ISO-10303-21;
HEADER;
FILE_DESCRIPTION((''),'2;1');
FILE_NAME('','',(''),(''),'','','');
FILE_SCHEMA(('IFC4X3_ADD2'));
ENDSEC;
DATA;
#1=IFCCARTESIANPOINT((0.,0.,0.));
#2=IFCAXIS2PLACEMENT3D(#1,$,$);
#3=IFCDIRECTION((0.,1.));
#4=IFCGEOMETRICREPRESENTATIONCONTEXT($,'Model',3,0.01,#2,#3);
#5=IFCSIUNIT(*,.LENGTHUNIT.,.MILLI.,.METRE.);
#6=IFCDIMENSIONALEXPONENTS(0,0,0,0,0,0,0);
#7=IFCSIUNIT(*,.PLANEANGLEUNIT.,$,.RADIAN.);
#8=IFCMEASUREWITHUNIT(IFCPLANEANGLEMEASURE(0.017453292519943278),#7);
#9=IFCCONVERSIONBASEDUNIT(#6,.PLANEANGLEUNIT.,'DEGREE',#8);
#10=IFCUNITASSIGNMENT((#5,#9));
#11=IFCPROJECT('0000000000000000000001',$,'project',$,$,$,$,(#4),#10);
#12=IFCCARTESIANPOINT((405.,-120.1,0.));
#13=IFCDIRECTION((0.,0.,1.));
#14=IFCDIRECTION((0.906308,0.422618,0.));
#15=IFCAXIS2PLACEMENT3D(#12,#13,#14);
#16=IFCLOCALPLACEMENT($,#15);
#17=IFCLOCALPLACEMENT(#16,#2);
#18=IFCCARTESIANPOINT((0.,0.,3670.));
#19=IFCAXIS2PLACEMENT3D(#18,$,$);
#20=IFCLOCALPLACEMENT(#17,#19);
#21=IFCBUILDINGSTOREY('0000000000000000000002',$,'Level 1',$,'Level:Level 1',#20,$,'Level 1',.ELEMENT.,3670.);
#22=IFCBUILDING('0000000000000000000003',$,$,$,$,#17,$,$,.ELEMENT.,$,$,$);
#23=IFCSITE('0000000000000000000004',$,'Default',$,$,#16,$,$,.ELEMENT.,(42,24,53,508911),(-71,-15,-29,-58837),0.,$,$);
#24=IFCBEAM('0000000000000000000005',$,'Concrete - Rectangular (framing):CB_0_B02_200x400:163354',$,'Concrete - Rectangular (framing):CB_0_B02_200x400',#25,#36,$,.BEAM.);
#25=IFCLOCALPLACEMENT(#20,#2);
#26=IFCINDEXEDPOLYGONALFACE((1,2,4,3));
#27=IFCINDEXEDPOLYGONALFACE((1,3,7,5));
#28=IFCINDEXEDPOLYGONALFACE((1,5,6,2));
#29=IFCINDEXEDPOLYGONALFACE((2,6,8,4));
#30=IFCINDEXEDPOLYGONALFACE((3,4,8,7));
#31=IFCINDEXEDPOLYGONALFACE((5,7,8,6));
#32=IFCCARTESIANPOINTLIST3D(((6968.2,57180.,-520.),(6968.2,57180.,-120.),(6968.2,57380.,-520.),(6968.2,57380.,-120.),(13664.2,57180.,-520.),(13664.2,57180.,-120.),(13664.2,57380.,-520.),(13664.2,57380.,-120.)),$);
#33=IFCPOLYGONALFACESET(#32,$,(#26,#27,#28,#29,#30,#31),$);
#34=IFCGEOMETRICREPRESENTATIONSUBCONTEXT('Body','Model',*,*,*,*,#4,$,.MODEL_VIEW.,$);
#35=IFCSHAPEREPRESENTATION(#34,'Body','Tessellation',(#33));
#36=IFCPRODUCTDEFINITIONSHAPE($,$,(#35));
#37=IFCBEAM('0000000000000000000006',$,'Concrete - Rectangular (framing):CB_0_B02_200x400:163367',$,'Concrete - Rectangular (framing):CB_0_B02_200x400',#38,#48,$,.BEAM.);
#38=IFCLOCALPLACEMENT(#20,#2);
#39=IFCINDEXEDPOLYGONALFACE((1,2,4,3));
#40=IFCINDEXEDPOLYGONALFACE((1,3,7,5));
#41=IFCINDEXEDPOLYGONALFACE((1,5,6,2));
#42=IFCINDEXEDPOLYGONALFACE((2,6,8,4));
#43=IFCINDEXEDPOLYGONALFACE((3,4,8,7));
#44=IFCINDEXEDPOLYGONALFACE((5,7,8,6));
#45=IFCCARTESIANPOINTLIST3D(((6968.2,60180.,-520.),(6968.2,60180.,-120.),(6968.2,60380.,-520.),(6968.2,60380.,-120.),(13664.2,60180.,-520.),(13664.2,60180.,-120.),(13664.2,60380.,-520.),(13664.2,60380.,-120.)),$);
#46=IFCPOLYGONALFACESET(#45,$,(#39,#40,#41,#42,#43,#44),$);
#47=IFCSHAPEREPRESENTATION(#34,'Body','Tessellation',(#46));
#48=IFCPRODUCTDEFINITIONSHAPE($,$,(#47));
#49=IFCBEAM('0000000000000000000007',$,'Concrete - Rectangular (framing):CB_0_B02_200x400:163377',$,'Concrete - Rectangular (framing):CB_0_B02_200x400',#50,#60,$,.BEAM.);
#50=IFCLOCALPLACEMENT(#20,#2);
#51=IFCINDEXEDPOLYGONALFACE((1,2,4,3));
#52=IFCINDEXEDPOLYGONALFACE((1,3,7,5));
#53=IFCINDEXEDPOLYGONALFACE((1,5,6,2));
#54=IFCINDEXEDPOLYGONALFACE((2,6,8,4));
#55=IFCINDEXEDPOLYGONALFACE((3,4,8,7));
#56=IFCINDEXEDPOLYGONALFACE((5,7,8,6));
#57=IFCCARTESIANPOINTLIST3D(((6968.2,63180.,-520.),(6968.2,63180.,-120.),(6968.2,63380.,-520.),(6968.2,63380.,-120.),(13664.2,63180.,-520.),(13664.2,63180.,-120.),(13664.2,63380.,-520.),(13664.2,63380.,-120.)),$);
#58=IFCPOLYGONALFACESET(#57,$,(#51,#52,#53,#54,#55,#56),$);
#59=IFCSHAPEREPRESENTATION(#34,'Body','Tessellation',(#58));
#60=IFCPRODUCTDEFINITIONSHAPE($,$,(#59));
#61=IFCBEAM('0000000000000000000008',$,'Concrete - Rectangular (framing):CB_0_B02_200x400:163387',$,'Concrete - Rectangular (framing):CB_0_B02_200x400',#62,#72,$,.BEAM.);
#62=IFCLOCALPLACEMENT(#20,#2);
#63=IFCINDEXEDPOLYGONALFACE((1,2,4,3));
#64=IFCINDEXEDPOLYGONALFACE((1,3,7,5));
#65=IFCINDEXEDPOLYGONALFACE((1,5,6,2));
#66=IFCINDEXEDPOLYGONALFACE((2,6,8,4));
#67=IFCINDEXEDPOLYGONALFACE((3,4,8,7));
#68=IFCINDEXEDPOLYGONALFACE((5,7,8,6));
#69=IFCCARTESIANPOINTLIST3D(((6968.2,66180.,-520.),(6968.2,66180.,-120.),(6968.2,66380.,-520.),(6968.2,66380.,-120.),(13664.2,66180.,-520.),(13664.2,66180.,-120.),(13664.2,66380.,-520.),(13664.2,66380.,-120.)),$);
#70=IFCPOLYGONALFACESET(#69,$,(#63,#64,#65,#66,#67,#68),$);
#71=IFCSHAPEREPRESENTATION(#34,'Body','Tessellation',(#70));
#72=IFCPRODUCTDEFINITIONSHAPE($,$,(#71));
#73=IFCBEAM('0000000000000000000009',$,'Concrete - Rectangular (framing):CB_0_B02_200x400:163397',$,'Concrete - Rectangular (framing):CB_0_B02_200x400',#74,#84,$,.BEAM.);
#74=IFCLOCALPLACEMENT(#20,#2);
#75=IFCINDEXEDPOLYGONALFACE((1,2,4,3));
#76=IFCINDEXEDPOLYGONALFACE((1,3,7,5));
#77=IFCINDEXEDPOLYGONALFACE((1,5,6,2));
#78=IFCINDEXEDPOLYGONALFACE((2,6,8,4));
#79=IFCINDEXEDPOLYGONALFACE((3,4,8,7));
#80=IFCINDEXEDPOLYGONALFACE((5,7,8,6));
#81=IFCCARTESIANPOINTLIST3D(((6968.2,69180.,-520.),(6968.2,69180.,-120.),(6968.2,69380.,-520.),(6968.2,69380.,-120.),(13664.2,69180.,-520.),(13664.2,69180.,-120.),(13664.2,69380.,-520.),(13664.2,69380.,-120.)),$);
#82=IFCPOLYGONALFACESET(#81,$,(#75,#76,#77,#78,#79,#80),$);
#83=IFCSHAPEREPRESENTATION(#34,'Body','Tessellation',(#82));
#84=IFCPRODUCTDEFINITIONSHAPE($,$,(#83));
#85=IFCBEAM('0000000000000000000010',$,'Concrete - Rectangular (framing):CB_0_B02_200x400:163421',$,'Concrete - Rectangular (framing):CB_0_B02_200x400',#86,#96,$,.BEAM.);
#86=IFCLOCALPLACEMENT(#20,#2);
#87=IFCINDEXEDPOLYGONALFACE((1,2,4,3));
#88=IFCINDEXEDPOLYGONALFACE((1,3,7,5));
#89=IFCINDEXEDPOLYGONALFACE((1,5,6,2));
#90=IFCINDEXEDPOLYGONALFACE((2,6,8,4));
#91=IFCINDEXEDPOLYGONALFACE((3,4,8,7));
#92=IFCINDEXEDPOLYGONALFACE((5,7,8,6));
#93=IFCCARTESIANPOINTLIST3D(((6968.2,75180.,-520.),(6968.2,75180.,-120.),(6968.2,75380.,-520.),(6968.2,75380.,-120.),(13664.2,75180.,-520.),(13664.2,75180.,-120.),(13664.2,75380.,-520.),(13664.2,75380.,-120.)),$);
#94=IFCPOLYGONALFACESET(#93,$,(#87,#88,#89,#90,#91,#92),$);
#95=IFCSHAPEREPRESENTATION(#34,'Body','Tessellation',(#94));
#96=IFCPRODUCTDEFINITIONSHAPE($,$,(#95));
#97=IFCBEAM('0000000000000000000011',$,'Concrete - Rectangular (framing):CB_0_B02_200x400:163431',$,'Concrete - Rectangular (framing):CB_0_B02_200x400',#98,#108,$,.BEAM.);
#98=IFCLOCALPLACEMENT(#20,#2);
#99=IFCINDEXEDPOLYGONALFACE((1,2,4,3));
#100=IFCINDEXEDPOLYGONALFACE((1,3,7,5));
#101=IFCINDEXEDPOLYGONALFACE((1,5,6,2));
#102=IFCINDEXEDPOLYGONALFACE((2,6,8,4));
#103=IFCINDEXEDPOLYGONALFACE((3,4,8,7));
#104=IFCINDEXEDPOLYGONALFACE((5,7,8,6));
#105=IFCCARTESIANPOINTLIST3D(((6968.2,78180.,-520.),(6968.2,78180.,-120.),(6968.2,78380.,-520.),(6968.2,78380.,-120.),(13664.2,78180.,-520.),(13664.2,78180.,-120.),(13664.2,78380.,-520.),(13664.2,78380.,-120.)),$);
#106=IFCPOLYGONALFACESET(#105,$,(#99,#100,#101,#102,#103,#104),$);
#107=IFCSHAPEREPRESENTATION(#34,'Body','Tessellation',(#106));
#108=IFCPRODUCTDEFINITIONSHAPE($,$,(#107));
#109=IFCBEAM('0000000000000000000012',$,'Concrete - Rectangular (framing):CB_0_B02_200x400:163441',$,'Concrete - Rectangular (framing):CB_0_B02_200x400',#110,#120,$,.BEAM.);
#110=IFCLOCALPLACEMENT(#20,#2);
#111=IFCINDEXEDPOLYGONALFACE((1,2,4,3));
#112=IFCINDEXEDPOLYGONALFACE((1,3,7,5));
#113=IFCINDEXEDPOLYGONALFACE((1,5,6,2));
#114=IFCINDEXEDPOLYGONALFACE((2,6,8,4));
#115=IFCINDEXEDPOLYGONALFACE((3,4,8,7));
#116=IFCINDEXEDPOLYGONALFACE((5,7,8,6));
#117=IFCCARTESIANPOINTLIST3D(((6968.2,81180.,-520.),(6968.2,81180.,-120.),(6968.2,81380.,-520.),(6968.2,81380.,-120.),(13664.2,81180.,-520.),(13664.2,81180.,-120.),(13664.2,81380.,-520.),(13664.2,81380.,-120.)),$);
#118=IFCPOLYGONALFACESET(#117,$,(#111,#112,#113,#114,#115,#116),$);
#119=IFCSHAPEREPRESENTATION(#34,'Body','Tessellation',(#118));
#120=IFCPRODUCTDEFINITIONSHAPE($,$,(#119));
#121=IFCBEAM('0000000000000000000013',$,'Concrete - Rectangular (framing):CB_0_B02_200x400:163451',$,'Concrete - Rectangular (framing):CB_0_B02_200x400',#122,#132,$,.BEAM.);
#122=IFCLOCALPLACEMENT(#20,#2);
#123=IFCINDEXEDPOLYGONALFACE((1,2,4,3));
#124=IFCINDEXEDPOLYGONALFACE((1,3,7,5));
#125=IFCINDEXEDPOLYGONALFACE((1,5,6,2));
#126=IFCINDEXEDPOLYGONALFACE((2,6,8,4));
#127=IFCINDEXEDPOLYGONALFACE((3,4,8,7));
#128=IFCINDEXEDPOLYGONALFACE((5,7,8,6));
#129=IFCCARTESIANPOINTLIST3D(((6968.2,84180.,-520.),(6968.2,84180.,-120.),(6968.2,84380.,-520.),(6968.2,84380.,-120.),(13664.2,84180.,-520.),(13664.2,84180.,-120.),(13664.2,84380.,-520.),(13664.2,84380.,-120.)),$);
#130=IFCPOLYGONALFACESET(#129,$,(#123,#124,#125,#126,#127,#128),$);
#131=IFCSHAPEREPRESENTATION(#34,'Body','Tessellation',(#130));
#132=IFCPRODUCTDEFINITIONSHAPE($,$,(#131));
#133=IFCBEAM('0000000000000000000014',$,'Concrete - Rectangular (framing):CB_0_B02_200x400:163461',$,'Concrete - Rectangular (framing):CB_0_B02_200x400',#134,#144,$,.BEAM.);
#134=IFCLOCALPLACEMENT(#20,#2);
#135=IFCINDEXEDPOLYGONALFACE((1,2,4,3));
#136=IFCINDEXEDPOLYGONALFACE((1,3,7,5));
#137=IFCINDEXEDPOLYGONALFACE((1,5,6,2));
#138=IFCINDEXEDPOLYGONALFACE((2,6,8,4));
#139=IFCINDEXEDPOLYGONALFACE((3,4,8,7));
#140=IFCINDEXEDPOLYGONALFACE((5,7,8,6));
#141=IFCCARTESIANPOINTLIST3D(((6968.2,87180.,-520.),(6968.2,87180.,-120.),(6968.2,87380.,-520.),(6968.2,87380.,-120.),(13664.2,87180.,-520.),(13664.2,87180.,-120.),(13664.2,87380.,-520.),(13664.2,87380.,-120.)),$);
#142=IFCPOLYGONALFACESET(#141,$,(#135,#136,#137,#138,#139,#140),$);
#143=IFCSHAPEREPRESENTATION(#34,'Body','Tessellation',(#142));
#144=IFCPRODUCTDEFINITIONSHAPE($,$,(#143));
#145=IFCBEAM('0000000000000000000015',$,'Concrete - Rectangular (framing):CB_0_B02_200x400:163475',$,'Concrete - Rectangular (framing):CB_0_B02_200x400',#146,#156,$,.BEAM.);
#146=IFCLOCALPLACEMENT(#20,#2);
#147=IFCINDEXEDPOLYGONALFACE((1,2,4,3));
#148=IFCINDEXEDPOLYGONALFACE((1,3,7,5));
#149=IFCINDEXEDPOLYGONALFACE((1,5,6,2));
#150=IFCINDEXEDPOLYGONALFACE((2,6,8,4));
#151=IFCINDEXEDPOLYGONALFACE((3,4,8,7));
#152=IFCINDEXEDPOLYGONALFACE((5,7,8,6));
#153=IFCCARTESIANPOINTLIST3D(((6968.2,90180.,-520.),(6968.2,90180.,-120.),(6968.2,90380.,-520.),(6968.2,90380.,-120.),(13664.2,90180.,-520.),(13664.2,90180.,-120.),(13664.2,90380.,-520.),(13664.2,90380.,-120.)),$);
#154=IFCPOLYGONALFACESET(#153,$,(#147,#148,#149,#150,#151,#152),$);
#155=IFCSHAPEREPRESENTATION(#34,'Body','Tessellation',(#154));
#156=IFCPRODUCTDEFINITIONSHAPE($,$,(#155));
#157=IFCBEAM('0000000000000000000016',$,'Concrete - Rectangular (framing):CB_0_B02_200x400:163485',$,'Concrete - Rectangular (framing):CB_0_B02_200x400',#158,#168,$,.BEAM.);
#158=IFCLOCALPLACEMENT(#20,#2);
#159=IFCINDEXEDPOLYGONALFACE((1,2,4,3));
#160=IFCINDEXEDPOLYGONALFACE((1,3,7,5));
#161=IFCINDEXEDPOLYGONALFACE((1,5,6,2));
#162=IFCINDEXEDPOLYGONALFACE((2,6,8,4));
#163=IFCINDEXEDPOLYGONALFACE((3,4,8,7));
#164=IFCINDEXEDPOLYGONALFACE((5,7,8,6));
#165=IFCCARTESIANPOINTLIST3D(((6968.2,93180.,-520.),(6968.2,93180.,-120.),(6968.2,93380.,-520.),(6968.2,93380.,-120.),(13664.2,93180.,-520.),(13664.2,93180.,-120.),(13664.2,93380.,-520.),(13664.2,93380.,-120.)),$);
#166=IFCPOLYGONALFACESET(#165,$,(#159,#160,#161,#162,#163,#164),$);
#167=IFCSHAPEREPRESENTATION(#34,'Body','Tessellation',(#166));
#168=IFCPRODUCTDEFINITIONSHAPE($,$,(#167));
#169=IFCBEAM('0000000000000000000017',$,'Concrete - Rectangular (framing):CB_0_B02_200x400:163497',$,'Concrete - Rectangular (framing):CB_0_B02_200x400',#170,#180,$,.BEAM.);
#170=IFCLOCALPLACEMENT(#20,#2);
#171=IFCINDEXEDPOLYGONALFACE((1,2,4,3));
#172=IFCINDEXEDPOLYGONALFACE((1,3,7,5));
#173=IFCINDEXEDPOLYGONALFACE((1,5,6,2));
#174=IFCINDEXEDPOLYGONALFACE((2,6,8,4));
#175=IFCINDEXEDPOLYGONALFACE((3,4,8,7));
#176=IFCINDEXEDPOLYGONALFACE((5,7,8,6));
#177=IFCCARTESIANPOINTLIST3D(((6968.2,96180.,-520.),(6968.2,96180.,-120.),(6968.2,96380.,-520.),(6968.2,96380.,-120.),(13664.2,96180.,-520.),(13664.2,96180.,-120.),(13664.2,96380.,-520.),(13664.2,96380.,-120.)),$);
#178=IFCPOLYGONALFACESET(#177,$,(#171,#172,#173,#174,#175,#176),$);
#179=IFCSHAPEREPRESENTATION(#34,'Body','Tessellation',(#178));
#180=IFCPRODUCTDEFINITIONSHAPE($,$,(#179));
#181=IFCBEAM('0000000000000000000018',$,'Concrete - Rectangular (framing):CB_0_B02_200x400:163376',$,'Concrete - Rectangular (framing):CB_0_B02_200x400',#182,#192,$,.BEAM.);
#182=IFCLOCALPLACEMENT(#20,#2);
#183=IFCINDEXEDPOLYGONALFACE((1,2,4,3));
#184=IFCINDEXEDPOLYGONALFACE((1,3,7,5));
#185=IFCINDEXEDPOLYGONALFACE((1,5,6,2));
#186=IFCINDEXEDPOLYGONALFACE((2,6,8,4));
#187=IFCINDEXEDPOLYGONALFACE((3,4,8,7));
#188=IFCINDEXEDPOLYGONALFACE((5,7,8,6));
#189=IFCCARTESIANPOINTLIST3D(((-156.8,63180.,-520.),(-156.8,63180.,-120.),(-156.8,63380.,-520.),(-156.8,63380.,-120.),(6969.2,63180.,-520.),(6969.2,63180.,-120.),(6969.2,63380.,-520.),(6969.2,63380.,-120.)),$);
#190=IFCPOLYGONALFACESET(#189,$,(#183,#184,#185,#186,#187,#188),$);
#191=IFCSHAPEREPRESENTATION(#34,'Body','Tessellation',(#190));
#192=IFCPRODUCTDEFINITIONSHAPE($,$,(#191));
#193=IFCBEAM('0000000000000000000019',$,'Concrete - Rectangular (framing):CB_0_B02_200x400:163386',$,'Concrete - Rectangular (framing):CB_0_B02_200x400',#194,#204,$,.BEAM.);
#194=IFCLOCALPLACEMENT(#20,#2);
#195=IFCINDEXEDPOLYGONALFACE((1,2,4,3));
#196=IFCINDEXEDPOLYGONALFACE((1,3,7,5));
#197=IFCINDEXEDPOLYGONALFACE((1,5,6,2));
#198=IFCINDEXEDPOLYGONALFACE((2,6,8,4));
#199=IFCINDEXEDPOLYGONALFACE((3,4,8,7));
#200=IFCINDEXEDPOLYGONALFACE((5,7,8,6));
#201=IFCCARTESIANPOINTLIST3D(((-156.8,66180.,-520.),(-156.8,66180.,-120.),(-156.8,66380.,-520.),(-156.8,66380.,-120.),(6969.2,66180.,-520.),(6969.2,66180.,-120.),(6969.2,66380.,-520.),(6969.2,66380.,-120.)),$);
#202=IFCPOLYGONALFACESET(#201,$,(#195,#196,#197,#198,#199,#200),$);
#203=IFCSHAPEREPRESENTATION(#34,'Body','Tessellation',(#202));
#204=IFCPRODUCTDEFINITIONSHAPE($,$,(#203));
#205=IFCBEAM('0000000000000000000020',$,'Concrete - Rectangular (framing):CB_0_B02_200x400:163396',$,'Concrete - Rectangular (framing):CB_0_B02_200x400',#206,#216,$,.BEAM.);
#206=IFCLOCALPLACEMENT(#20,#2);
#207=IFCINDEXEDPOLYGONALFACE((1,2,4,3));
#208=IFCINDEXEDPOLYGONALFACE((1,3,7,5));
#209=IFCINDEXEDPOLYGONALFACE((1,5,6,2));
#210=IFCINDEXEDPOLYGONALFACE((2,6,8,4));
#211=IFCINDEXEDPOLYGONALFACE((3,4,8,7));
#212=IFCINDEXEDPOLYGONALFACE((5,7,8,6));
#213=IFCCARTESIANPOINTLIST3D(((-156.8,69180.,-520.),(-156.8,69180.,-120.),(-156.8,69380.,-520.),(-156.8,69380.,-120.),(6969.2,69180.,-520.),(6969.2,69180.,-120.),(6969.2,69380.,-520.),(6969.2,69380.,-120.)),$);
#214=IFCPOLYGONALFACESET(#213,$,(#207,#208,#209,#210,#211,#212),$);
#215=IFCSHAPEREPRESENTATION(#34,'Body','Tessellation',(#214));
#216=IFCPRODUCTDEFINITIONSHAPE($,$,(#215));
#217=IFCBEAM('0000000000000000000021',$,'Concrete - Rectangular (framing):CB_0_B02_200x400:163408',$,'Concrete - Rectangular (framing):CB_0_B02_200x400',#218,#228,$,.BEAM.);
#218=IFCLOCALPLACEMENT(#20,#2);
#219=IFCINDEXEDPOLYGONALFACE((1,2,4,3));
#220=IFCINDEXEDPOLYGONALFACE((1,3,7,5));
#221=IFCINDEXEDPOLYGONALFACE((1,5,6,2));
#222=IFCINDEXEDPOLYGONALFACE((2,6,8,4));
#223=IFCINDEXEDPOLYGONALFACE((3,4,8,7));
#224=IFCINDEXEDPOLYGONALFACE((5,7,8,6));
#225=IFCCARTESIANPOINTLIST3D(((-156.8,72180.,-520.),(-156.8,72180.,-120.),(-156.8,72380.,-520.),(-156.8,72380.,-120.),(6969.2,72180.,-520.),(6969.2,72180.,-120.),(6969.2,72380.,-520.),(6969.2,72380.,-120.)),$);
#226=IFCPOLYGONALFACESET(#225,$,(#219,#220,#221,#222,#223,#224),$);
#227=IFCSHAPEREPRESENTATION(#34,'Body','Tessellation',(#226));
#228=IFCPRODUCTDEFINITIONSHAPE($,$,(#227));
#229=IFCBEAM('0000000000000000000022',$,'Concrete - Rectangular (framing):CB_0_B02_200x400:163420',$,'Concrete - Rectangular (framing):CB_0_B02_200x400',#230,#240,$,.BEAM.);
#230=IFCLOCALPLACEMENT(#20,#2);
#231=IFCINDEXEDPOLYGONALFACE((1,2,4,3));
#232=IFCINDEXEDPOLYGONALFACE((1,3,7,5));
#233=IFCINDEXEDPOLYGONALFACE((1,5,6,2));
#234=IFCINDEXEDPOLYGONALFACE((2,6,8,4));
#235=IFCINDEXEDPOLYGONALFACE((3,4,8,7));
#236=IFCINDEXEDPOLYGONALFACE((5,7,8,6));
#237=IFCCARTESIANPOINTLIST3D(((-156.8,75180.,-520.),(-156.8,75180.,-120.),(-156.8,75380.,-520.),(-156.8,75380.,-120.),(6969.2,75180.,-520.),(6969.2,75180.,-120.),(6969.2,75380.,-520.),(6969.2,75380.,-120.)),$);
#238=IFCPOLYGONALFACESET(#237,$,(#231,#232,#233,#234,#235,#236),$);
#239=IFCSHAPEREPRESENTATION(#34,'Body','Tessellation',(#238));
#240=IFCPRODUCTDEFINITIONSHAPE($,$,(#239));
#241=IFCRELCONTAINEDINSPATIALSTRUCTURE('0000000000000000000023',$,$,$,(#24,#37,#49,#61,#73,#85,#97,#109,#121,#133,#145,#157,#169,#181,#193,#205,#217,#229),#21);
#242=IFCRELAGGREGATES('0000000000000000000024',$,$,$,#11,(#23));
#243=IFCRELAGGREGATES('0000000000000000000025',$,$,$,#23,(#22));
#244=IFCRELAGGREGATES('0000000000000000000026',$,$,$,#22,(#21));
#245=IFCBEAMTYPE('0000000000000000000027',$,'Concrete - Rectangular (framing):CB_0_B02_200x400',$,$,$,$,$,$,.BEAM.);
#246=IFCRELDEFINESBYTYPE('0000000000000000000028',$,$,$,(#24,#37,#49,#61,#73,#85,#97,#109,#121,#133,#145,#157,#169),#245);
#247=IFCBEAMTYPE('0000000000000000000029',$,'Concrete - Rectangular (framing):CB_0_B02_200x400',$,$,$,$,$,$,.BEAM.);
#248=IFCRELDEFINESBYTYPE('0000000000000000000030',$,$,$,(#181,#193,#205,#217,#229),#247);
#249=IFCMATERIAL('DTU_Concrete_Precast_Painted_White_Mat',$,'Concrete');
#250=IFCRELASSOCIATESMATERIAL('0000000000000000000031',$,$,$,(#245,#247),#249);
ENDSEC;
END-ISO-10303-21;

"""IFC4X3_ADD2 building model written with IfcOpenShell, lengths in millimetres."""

from ifc_helpers import new_model, entity, si_unit, converted_unit, direction, frame, frame_2d, origin, origin_2d_with_axis, place, context, subcontext, project, spatial, rectangle, extrude, source, transform, mapped, material, material_profile, profile_set, type_object, type_shapes, element, save


model = new_model("IFC4X3_ADD2")

# Units and contexts
model_context = context("Model", 3, precision=0.01, world=origin(), true_north=direction((0.0, 1.0)))
body_context = subcontext(model_context, "Body", "Model", "MODEL_VIEW")
ifc_project = project(units=[si_unit("LENGTHUNIT", "METRE", prefix="MILLI"), converted_unit("PLANEANGLEUNIT", "DEGREE", entity("IfcPlaneAngleMeasure", 0.017453292519943278), si_unit("PLANEANGLEUNIT", "RADIAN"), dimensions=[0, 0, 0, 0, 0, 0, 0])], contexts=[model_context])

# Site, building, storey
site_placement = place(None, frame((405.0, -120.1, 0.0), z_axis=(0.0, 0.0, 1.0), x_axis=(0.906308, 0.422618, 0.0)))
site = spatial("IfcSite", under=ifc_project, at=site_placement, Name="Default", CompositionType="ELEMENT", RefLatitude=(42, 24, 53, 508911), RefLongitude=(-71, -15, -29, -58837), RefElevation=0.0)
building_placement = place(site_placement, origin())
building = spatial("IfcBuilding", under=site, at=building_placement, CompositionType="ELEMENT")
storey_placement = place(building_placement, frame((0.0, 0.0, 3670.0)))
storey = spatial("IfcBuildingStorey", under=building, at=storey_placement, Name="Level 1", ObjectType="Level:Level 1", LongName="Level 1", CompositionType="ELEMENT", Elevation=3670.0)

# Beams
ifc_material = material(Name="DTU_Concrete_Precast_Painted_White_Mat", Category="Concrete")
ifc_material_profile_1 = material_profile(ifc_material, rectangle(XDim=7035.5, YDim=200.0, at=frame_2d((0.0, 0.0), x_axis=(1.0, 0.0))), Name="CB_0_B02_200x400")
ifc_profile_set_1 = profile_set([ifc_material_profile_1], Name="CB_0_B02_200x400")
beam_type_1 = type_object("IfcBeamType", Name="Concrete - Rectangular (framing):CB_0_B02_200x400", PredefinedType="BEAM", material=ifc_profile_set_1)
shared_shape_1 = source(origin(), body_context, "Body", "SweptSolid", [
    extrude(rectangle(XDim=6696.0, YDim=200.0, at=origin_2d_with_axis()), frame((0.0, 0.0, -200.0), z_axis=(0.0, 0.0, 1.0), x_axis=(-1.0, 0.0, 0.0)), (0.0, 0.0, 1.0), 400.0),
])
type_shapes(beam_type_1, [shared_shape_1])
for number, where, name in (
    (1, (10316.2, 57280.0, -320.0), "Concrete - Rectangular (framing):CB_0_B02_200x400:163354"),
    (2, (10316.2, 60280.0, -320.0), "Concrete - Rectangular (framing):CB_0_B02_200x400:163367"),
    (3, (10316.2, 63280.0, -320.0), "Concrete - Rectangular (framing):CB_0_B02_200x400:163377"),
    (4, (10316.2, 66280.0, -320.0), "Concrete - Rectangular (framing):CB_0_B02_200x400:163387"),
    (5, (10316.2, 69280.0, -320.0), "Concrete - Rectangular (framing):CB_0_B02_200x400:163397"),
    (6, (10316.2, 75280.0, -320.0), "Concrete - Rectangular (framing):CB_0_B02_200x400:163421"),
    (7, (10316.2, 78280.0, -320.0), "Concrete - Rectangular (framing):CB_0_B02_200x400:163431"),
    (8, (10316.2, 81280.0, -320.0), "Concrete - Rectangular (framing):CB_0_B02_200x400:163441"),
    (9, (10316.2, 84280.0, -320.0), "Concrete - Rectangular (framing):CB_0_B02_200x400:163451"),
    (10, (10316.2, 87280.0, -320.0), "Concrete - Rectangular (framing):CB_0_B02_200x400:163461"),
    (11, (10316.2, 90280.0, -320.0), "Concrete - Rectangular (framing):CB_0_B02_200x400:163475"),
    (12, (10316.2, 93280.0, -320.0), "Concrete - Rectangular (framing):CB_0_B02_200x400:163485"),
    (13, (10316.2, 96280.0, -320.0), "Concrete - Rectangular (framing):CB_0_B02_200x400:163497"),
):
    element("IfcBeam", number, at=place(storey_placement, frame(where)), inside=storey, type_object=beam_type_1, Name=name, ObjectType="Concrete - Rectangular (framing):CB_0_B02_200x400", PredefinedType="BEAM", context=body_context, shape_type="MappedRepresentation", body=[
        mapped(shared_shape_1, transform((0.0, 0.0, 0.0), scale=1.0)),
    ])
beam_type_2 = type_object("IfcBeamType", Name="Concrete - Rectangular (framing):CB_0_B02_200x400", PredefinedType="BEAM", material=ifc_profile_set_1)
shared_shape_2 = source(origin(), body_context, "Body", "SweptSolid", [
    extrude(rectangle(XDim=7126.0, YDim=200.0, at=origin_2d_with_axis()), frame((0.0, 0.0, -200.0), z_axis=(0.0, 0.0, 1.0), x_axis=(-1.0, 0.0, 0.0)), (0.0, 0.0, 1.0), 400.0),
])
type_shapes(beam_type_2, [shared_shape_2])
for number, where, z_axis, x_axis, name in (
    (14, (3406.2, 63280.0, -320.0), (0.0, 0.0, 1.0), (-1.0, 0.0, 0.0), "Concrete - Rectangular (framing):CB_0_B02_200x400:163376"),
    (15, (3406.2, 66280.0, -320.0), (0.0, 0.0, 1.0), (-1.0, 0.0, 0.0), "Concrete - Rectangular (framing):CB_0_B02_200x400:163386"),
    (16, (3406.2, 69280.0, -320.0), (0.0, 0.0, 1.0), (-1.0, 0.0, 0.0), "Concrete - Rectangular (framing):CB_0_B02_200x400:163396"),
    (17, (3406.2, 72280.0, -320.0), (0.0, 0.0, 1.0), (-1.0, 0.0, 0.0), "Concrete - Rectangular (framing):CB_0_B02_200x400:163408"),
    (18, (3406.2, 75280.0, -320.0), (0.0, 0.0, 1.0), (-1.0, 0.0, 0.0), "Concrete - Rectangular (framing):CB_0_B02_200x400:163420"),
):
    element("IfcBeam", number, at=place(storey_placement, frame(where, z_axis=z_axis, x_axis=x_axis)), inside=storey, type_object=beam_type_2, Name=name, ObjectType="Concrete - Rectangular (framing):CB_0_B02_200x400", PredefinedType="BEAM", context=body_context, shape_type="MappedRepresentation", body=[
        mapped(shared_shape_2, transform((0.0, 0.0, 0.0), scale=1.0)),
    ])

save(model, "model.ifc")
